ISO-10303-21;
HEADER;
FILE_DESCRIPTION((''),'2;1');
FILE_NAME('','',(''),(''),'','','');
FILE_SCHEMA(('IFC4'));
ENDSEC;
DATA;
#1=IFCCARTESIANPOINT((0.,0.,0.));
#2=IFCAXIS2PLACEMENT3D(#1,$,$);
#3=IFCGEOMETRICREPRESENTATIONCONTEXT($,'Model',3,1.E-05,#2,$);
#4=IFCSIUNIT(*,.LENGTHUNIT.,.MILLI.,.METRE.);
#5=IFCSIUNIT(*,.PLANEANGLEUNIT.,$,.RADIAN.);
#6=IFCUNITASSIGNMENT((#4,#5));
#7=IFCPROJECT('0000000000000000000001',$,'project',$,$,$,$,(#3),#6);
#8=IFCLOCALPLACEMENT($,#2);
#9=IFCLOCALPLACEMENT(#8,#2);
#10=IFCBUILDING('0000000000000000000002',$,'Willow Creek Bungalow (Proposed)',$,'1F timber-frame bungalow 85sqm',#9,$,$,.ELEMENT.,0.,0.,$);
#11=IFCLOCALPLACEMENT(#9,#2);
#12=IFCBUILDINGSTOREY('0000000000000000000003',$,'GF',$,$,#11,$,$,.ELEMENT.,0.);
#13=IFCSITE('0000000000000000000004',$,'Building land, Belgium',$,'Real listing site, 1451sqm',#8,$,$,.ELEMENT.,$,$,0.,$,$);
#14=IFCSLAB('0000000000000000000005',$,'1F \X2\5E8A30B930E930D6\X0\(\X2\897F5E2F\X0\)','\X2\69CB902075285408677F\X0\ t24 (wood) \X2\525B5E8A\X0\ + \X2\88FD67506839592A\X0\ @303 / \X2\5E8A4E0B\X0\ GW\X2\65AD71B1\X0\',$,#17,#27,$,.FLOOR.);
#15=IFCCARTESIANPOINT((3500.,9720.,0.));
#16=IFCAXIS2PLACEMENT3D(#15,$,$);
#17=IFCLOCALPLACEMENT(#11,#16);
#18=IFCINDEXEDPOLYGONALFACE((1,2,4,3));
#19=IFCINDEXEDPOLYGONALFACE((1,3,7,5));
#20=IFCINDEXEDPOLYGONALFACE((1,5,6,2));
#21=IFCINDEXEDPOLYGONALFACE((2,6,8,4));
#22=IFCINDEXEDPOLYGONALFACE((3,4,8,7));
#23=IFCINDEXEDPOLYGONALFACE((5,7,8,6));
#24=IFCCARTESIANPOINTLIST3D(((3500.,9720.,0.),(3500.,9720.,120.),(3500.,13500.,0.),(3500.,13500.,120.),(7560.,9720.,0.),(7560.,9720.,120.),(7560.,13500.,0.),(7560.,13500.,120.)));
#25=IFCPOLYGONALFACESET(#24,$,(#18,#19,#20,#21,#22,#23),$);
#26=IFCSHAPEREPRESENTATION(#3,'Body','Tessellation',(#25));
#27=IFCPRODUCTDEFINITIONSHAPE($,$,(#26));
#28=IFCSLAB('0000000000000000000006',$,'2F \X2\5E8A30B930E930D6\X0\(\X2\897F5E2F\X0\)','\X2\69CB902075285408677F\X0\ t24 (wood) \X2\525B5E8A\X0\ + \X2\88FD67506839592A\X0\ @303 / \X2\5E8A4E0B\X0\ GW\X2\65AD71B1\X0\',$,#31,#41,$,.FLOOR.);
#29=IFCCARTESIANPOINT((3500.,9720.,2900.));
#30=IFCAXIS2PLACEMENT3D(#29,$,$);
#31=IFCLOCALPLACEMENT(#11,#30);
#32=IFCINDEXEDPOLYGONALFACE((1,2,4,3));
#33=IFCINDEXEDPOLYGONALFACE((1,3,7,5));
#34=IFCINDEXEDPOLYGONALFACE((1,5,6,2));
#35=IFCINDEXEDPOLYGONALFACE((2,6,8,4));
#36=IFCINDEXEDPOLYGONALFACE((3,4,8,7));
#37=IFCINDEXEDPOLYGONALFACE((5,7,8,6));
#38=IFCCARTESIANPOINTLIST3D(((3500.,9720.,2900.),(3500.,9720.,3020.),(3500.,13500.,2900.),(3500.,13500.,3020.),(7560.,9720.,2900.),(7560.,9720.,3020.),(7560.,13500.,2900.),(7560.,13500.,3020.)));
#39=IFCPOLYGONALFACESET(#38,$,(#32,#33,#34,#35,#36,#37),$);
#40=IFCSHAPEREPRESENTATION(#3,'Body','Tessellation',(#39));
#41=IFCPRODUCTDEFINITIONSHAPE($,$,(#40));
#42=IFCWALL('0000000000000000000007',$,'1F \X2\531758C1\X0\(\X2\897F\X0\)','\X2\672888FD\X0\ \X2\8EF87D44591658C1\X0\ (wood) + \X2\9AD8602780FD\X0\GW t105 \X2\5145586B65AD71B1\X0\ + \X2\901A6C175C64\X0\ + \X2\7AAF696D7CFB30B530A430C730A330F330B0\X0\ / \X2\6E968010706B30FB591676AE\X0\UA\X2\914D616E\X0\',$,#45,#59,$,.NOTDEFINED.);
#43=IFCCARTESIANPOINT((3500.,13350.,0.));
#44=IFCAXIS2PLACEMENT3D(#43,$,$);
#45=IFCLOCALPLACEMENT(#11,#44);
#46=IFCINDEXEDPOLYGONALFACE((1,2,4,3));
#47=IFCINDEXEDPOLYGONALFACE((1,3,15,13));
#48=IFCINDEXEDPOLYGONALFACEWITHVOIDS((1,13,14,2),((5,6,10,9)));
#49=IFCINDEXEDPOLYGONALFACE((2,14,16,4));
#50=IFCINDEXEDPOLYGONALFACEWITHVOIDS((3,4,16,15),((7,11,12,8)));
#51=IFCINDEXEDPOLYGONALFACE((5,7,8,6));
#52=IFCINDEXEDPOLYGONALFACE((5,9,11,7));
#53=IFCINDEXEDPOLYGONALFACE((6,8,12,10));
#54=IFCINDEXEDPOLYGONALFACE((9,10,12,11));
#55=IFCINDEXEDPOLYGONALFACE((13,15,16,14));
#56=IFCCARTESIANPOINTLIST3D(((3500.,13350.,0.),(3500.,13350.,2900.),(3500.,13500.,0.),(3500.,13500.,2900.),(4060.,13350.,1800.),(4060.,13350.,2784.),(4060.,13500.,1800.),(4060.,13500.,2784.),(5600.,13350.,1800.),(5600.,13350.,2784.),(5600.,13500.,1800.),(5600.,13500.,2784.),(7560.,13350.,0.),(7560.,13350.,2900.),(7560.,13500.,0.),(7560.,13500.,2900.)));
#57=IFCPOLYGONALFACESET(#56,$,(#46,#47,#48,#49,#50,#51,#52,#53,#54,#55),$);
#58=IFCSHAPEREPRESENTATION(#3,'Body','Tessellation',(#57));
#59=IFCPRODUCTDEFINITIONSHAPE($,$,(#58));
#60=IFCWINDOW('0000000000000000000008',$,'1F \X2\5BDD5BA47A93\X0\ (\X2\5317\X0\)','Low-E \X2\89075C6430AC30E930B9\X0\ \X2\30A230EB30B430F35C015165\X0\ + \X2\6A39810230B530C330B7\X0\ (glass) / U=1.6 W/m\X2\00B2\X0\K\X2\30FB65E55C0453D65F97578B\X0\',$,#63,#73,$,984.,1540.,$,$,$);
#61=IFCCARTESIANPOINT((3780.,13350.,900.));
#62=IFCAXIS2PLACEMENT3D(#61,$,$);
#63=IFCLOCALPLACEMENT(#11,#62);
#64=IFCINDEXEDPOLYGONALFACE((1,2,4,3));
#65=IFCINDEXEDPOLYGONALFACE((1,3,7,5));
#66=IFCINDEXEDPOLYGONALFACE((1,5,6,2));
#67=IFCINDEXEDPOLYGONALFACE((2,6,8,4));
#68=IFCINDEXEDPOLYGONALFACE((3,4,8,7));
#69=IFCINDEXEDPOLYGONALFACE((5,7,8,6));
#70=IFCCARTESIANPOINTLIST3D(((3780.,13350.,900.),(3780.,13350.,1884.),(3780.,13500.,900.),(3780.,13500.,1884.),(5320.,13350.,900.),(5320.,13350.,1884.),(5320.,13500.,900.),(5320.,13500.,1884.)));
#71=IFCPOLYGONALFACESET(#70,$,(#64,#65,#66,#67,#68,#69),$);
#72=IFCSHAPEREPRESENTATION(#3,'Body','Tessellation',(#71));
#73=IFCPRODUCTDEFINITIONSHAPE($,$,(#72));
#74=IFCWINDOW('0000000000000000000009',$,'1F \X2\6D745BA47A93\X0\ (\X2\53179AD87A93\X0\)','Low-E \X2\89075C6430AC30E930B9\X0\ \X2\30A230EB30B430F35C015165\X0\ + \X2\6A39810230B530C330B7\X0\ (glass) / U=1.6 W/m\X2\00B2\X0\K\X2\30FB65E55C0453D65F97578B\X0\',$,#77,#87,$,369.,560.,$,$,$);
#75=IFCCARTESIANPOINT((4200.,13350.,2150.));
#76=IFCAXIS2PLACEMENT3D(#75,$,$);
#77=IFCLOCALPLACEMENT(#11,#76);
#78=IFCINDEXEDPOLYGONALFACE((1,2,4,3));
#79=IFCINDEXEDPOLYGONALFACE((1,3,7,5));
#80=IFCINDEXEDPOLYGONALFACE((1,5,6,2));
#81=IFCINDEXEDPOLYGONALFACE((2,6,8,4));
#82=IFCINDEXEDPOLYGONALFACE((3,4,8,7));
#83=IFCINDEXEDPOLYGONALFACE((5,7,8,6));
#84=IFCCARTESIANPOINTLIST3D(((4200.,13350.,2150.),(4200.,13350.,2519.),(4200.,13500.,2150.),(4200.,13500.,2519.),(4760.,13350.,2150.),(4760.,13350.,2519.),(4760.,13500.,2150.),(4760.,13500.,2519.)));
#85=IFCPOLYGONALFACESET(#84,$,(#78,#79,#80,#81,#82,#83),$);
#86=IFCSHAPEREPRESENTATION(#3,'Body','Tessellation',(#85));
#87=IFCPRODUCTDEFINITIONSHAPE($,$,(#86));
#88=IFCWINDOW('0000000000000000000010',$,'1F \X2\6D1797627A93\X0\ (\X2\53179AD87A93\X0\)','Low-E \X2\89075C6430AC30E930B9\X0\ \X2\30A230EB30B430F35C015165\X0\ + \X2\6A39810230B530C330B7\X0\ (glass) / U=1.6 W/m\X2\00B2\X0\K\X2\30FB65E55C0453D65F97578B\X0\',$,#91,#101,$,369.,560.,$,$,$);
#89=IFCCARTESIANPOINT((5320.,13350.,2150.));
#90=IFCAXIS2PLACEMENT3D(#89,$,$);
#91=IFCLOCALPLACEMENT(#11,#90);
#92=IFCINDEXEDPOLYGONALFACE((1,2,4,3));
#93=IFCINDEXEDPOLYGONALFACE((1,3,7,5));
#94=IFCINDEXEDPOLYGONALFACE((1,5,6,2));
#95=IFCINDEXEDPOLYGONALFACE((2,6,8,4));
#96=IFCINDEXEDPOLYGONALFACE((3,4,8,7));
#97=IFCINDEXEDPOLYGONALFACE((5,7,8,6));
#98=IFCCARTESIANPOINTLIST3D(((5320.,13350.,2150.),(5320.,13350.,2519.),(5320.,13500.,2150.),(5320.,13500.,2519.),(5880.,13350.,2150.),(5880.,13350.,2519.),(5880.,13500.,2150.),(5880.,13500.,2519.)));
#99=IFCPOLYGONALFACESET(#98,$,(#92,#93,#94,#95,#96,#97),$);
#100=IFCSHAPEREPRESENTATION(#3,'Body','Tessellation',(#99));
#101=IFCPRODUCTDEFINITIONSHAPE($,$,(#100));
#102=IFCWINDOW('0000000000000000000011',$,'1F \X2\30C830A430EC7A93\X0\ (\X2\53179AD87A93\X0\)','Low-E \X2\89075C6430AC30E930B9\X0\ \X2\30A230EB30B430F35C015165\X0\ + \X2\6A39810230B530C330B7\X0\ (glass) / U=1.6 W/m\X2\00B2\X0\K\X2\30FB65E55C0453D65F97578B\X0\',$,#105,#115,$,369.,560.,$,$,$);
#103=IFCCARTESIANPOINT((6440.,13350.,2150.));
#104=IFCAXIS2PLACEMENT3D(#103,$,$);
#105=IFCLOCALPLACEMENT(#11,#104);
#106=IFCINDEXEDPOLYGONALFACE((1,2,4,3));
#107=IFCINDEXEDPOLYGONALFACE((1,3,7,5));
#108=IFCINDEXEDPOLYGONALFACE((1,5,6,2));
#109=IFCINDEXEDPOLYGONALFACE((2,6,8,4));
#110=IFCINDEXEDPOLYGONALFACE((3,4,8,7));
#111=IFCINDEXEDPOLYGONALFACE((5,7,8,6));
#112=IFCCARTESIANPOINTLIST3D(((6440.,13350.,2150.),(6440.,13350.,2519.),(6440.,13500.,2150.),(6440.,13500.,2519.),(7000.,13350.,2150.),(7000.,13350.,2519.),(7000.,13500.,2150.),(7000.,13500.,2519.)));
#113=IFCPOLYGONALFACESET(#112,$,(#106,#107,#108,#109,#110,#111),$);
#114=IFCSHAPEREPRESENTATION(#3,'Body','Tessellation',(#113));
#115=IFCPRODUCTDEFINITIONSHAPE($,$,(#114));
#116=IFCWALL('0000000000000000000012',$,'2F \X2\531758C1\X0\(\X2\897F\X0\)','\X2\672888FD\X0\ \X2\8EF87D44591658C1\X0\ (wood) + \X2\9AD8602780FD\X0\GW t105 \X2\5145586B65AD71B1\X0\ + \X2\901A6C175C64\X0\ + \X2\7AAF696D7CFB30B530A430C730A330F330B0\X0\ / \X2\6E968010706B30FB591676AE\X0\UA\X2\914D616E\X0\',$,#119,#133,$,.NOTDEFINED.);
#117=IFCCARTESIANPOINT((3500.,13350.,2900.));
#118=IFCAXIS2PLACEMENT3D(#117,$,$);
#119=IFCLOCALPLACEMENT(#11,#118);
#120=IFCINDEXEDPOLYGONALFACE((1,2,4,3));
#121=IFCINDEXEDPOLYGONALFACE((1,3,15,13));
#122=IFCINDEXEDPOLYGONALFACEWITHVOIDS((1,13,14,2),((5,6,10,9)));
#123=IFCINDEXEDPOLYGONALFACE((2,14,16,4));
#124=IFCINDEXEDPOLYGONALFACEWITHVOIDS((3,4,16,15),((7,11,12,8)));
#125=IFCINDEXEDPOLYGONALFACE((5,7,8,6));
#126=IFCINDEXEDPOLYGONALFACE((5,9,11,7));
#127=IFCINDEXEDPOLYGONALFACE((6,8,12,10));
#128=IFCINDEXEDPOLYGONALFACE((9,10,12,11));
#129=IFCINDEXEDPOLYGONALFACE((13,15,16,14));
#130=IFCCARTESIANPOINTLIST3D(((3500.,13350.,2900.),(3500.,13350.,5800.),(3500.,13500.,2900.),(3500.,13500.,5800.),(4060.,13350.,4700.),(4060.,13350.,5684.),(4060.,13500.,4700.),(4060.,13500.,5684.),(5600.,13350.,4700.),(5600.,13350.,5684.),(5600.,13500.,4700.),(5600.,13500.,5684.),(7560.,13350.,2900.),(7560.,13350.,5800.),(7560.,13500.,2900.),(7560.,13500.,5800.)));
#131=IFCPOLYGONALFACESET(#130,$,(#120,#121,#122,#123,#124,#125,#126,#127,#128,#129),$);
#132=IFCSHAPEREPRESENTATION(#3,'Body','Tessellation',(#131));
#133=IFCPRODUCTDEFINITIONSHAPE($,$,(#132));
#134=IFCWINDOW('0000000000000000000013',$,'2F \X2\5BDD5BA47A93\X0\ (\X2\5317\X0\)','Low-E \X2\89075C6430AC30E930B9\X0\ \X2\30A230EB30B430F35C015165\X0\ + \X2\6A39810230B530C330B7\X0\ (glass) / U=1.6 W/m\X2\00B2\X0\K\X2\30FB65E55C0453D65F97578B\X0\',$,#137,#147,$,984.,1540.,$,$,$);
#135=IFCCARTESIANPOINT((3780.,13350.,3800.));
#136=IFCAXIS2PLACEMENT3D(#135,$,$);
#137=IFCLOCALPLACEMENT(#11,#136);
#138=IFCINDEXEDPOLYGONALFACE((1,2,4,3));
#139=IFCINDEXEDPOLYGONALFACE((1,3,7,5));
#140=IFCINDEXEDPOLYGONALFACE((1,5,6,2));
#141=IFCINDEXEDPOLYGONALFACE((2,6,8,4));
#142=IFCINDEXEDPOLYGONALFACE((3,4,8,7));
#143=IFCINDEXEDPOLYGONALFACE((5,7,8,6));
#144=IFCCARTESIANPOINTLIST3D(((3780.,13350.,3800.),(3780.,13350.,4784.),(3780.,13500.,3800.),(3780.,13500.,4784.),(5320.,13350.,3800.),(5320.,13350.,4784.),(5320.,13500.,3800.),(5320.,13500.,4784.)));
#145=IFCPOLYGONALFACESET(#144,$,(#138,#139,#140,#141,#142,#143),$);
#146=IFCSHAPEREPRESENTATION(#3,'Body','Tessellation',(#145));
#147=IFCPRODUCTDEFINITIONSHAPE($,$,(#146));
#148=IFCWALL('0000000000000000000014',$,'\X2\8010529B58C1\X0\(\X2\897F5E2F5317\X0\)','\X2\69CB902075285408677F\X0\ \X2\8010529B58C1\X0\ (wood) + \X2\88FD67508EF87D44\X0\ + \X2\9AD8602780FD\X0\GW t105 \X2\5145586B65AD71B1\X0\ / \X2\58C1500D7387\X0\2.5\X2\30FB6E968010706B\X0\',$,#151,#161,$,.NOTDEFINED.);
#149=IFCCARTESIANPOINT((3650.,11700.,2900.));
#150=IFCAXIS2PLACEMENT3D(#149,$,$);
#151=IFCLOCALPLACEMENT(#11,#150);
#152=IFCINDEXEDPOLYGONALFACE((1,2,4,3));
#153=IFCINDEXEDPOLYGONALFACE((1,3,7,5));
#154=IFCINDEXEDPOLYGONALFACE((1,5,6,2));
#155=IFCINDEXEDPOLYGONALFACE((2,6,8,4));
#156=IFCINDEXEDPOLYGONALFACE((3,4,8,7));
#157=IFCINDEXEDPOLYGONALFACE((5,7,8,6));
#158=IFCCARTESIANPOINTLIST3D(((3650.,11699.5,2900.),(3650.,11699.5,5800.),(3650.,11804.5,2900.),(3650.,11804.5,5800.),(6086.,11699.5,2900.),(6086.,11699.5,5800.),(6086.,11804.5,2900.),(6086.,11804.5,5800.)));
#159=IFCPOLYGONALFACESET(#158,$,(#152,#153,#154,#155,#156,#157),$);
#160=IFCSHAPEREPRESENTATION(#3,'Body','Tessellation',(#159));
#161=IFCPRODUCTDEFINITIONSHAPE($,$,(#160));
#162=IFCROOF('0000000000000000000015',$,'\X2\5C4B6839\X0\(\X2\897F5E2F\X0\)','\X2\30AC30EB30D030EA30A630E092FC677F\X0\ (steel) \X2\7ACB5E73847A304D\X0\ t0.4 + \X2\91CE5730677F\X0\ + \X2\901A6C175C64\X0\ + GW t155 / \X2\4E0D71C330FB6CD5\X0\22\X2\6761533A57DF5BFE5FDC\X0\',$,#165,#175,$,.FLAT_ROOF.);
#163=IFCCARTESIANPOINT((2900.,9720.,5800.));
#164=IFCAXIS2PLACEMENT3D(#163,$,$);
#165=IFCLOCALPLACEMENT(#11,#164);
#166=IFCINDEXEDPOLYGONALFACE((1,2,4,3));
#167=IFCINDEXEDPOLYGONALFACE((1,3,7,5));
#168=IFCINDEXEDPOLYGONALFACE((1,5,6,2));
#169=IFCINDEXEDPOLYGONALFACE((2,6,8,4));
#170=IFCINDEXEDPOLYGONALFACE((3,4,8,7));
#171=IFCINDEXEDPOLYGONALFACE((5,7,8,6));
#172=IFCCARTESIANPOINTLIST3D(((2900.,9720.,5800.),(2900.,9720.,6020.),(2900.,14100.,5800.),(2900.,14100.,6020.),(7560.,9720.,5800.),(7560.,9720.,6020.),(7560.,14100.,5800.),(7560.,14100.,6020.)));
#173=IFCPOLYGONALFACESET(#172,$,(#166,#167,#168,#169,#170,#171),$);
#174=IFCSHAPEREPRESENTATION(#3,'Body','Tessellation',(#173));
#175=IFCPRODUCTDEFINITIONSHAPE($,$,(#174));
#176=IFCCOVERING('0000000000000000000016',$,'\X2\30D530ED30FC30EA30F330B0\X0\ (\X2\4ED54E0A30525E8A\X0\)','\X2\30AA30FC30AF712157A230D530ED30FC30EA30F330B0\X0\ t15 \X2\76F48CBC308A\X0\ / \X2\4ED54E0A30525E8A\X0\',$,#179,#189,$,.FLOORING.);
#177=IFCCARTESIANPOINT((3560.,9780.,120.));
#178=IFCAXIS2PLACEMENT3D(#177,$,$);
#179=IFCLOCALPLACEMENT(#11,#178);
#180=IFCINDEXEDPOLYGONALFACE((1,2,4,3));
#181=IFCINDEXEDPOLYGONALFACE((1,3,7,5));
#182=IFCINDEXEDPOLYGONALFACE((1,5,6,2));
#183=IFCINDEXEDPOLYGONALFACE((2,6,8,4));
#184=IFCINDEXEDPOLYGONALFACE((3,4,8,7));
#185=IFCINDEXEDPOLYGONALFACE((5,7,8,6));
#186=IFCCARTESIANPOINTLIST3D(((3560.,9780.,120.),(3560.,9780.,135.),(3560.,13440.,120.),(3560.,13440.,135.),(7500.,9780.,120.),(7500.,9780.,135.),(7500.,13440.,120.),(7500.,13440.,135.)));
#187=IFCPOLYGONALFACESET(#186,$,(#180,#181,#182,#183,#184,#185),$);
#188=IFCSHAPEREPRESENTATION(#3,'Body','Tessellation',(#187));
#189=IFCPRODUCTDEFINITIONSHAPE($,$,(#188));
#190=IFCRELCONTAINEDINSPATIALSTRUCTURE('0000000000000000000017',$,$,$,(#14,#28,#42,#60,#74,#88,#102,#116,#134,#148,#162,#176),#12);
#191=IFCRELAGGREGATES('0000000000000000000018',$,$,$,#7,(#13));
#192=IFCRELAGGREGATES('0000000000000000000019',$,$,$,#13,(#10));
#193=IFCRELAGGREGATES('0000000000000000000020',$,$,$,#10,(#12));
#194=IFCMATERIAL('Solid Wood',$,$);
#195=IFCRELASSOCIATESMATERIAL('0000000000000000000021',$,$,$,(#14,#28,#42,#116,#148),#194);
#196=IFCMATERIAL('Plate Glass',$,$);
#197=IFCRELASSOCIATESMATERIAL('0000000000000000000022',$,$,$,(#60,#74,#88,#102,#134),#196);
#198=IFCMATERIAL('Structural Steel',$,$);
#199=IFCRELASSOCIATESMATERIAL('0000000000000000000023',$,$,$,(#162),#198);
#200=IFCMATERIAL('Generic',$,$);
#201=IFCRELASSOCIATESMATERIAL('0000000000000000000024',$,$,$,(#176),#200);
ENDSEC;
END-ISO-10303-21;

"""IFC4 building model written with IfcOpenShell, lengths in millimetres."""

from ifc_helpers import new_model, si_unit, frame, frame_2d, origin, place, context, project, spatial, rectangle, extrude, material, element, fill, save


model = new_model("IFC4")

# Units and contexts
model_context = context("Model", 3, precision=1e-05, world=origin())
ifc_project = project(units=[si_unit("LENGTHUNIT", "METRE", prefix="MILLI"), si_unit("PLANEANGLEUNIT", "RADIAN")], contexts=[model_context])

# Site, building, storey
site_placement = place(None, origin())
site = spatial("IfcSite", under=ifc_project, at=site_placement, Name="Building land, Belgium", ObjectType="Real listing site, 1451sqm", CompositionType="ELEMENT", RefElevation=0.0)
building_placement = place(site_placement, origin())
building = spatial("IfcBuilding", under=site, at=building_placement, Name="Willow Creek Bungalow (Proposed)", ObjectType="1F timber-frame bungalow 85sqm", CompositionType="ELEMENT", ElevationOfRefHeight=0.0, ElevationOfTerrain=0.0)
storey_placement = place(building_placement, origin())
storey = spatial("IfcBuildingStorey", under=building, at=storey_placement, Name="GF", CompositionType="ELEMENT", Elevation=0.0)

# Slabs
ifc_material_1 = material(Name="Solid Wood")
slab_1_placement = place(storey_placement, frame((3500.0, 9720.0, 0.0)))
element("IfcSlab", 1, at=slab_1_placement, inside=storey, material=ifc_material_1, Name="1F 床スラブ(西帯)", Description="構造用合板 t24 (wood) 剛床 + 製材根太 @303 / 床下 GW断熱", PredefinedType="FLOOR", context=model_context, shape_type="SweptSolid", body=[
    extrude(rectangle(XDim=4060.0, YDim=3780.0, at=frame_2d((2030.0, 1890.0))), frame((3500.0, 9720.0, 0.0)), (0.0, 0.0, 1.0), 120.0),
])
slab_2_placement = place(storey_placement, frame((3500.0, 9720.0, 2900.0)))
element("IfcSlab", 2, at=slab_2_placement, inside=storey, material=ifc_material_1, Name="2F 床スラブ(西帯)", Description="構造用合板 t24 (wood) 剛床 + 製材根太 @303 / 床下 GW断熱", PredefinedType="FLOOR", context=model_context, shape_type="SweptSolid", body=[
    extrude(rectangle(XDim=4060.0, YDim=3780.0, at=frame_2d((2030.0, 1890.0))), frame((3500.0, 9720.0, 2900.0)), (0.0, 0.0, 1.0), 120.0),
])

# Wall, openings, windows
wall_1_placement = place(storey_placement, frame((3500.0, 13350.0, 0.0)))
wall_1 = element("IfcWall", 3, at=wall_1_placement, inside=storey, material=ifc_material_1, Name="1F 北壁(西)", Description="木製 軸組外壁 (wood) + 高性能GW t105 充填断熱 + 通気層 + 窯業系サイディング / 準耐火・外皮UA配慮", PredefinedType="NOTDEFINED", context=model_context, shape_type="SweptSolid", body=[
    extrude(rectangle(XDim=4060.0, YDim=150.0, at=frame_2d((2030.0, 75.0))), frame((3500.0, 13350.0, 0.0)), (0.0, 0.0, 1.0), 2900.0),
])
opening_1_placement = place(storey_placement, frame((3780.0, 13350.0, 900.0)))
opening_1 = element("IfcOpeningElement", 4, at=opening_1_placement, cuts=wall_1, PredefinedType="NOTDEFINED", context=model_context, shape_type="SweptSolid", body=[
    extrude(rectangle(XDim=1540.0, YDim=150.0, at=frame_2d((770.0, 75.0))), frame((3780.0, 13350.0, 900.0)), (0.0, 0.0, 1.0), 984.0),
])
opening_2_placement = place(storey_placement, frame((4200.0, 13350.0, 2150.0)))
opening_2 = element("IfcOpeningElement", 5, at=opening_2_placement, cuts=wall_1, PredefinedType="NOTDEFINED", context=model_context, shape_type="SweptSolid", body=[
    extrude(rectangle(XDim=560.0, YDim=150.0, at=frame_2d((280.0, 75.0))), frame((4200.0, 13350.0, 2150.0)), (0.0, 0.0, 1.0), 369.0),
])
opening_3_placement = place(storey_placement, frame((5320.0, 13350.0, 2150.0)))
opening_3 = element("IfcOpeningElement", 6, at=opening_3_placement, cuts=wall_1, PredefinedType="NOTDEFINED", context=model_context, shape_type="SweptSolid", body=[
    extrude(rectangle(XDim=560.0, YDim=150.0, at=frame_2d((280.0, 75.0))), frame((5320.0, 13350.0, 2150.0)), (0.0, 0.0, 1.0), 369.0),
])
opening_4_placement = place(storey_placement, frame((6440.0, 13350.0, 2150.0)))
opening_4 = element("IfcOpeningElement", 7, at=opening_4_placement, cuts=wall_1, PredefinedType="NOTDEFINED", context=model_context, shape_type="SweptSolid", body=[
    extrude(rectangle(XDim=560.0, YDim=150.0, at=frame_2d((280.0, 75.0))), frame((6440.0, 13350.0, 2150.0)), (0.0, 0.0, 1.0), 369.0),
])
ifc_material_2 = material(Name="Plate Glass")
window_1_placement = place(storey_placement, frame((3780.0, 13350.0, 900.0)))
window_1 = element("IfcWindow", 8, at=window_1_placement, inside=storey, material=ifc_material_2, Name="1F 寝室窓 (北)", Description="Low-E 複層ガラス アルゴン封入 + 樹脂サッシ (glass) / U=1.6 W/m²K・日射取得型", OverallHeight=984.0, OverallWidth=1540.0, context=model_context, shape_type="SweptSolid", body=[
    extrude(rectangle(XDim=1540.0, YDim=150.0, at=frame_2d((770.0, 75.0))), frame((3780.0, 13350.0, 900.0)), (0.0, 0.0, 1.0), 984.0),
])
fill(opening_1, window_1)
window_2_placement = place(storey_placement, frame((4200.0, 13350.0, 2150.0)))
window_2 = element("IfcWindow", 9, at=window_2_placement, inside=storey, material=ifc_material_2, Name="1F 浴室窓 (北高窓)", Description="Low-E 複層ガラス アルゴン封入 + 樹脂サッシ (glass) / U=1.6 W/m²K・日射取得型", OverallHeight=369.0, OverallWidth=560.0, context=model_context, shape_type="SweptSolid", body=[
    extrude(rectangle(XDim=560.0, YDim=150.0, at=frame_2d((280.0, 75.0))), frame((4200.0, 13350.0, 2150.0)), (0.0, 0.0, 1.0), 369.0),
])
fill(opening_2, window_2)
window_3_placement = place(storey_placement, frame((5320.0, 13350.0, 2150.0)))
window_3 = element("IfcWindow", 10, at=window_3_placement, inside=storey, material=ifc_material_2, Name="1F 洗面窓 (北高窓)", Description="Low-E 複層ガラス アルゴン封入 + 樹脂サッシ (glass) / U=1.6 W/m²K・日射取得型", OverallHeight=369.0, OverallWidth=560.0, context=model_context, shape_type="SweptSolid", body=[
    extrude(rectangle(XDim=560.0, YDim=150.0, at=frame_2d((280.0, 75.0))), frame((5320.0, 13350.0, 2150.0)), (0.0, 0.0, 1.0), 369.0),
])
fill(opening_3, window_3)
window_4_placement = place(storey_placement, frame((6440.0, 13350.0, 2150.0)))
window_4 = element("IfcWindow", 11, at=window_4_placement, inside=storey, material=ifc_material_2, Name="1F トイレ窓 (北高窓)", Description="Low-E 複層ガラス アルゴン封入 + 樹脂サッシ (glass) / U=1.6 W/m²K・日射取得型", OverallHeight=369.0, OverallWidth=560.0, context=model_context, shape_type="SweptSolid", body=[
    extrude(rectangle(XDim=560.0, YDim=150.0, at=frame_2d((280.0, 75.0))), frame((6440.0, 13350.0, 2150.0)), (0.0, 0.0, 1.0), 369.0),
])
fill(opening_4, window_4)

# Wall, opening, window
wall_2_placement = place(storey_placement, frame((3500.0, 13350.0, 2900.0)))
wall_2 = element("IfcWall", 12, at=wall_2_placement, inside=storey, material=ifc_material_1, Name="2F 北壁(西)", Description="木製 軸組外壁 (wood) + 高性能GW t105 充填断熱 + 通気層 + 窯業系サイディング / 準耐火・外皮UA配慮", PredefinedType="NOTDEFINED", context=model_context, shape_type="SweptSolid", body=[
    extrude(rectangle(XDim=4060.0, YDim=150.0, at=frame_2d((2030.0, 75.0))), frame((3500.0, 13350.0, 2900.0)), (0.0, 0.0, 1.0), 2900.0),
])
opening_5_placement = place(storey_placement, frame((3780.0, 13350.0, 3800.0)))
opening_5 = element("IfcOpeningElement", 13, at=opening_5_placement, cuts=wall_2, PredefinedType="NOTDEFINED", context=model_context, shape_type="SweptSolid", body=[
    extrude(rectangle(XDim=1540.0, YDim=150.0, at=frame_2d((770.0, 75.0))), frame((3780.0, 13350.0, 3800.0)), (0.0, 0.0, 1.0), 984.0),
])
window_5_placement = place(storey_placement, frame((3780.0, 13350.0, 3800.0)))
window_5 = element("IfcWindow", 14, at=window_5_placement, inside=storey, material=ifc_material_2, Name="2F 寝室窓 (北)", Description="Low-E 複層ガラス アルゴン封入 + 樹脂サッシ (glass) / U=1.6 W/m²K・日射取得型", OverallHeight=984.0, OverallWidth=1540.0, context=model_context, shape_type="SweptSolid", body=[
    extrude(rectangle(XDim=1540.0, YDim=150.0, at=frame_2d((770.0, 75.0))), frame((3780.0, 13350.0, 3800.0)), (0.0, 0.0, 1.0), 984.0),
])
fill(opening_5, window_5)

# Wall
wall_3_placement = place(storey_placement, frame((3650.0, 11700.0, 2900.0)))
element("IfcWall", 15, at=wall_3_placement, inside=storey, material=ifc_material_1, Name="耐力壁(西帯北)", Description="構造用合板 耐力壁 (wood) + 製材軸組 + 高性能GW t105 充填断熱 / 壁倍率2.5・準耐火", PredefinedType="NOTDEFINED", context=model_context, shape_type="SweptSolid", body=[
    extrude(rectangle(XDim=2436.0, YDim=105.0, at=frame_2d((1218.0, 52.0))), frame((3650.0, 11700.0, 2900.0)), (0.0, 0.0, 1.0), 2900.0),
])

# Roof
ifc_material_3 = material(Name="Structural Steel")
for number, where, name in (
    (16, (2900.0, 9720.0, 5800.0), "屋根(西帯)"),
):
    element("IfcRoof", number, at=place(storey_placement, frame(where)), inside=storey, material=ifc_material_3, Name=name, Description="ガルバリウム鋼板 (steel) 立平葺き t0.4 + 野地板 + 通気層 + GW t155 / 不燃・法22条区域対応", PredefinedType="FLAT_ROOF", context=model_context, shape_type="SweptSolid", body=[
        extrude(rectangle(XDim=4660.0, YDim=4380.0, at=frame_2d((2330.0, 2190.0))), frame((2900.0, 9720.0, 5800.0)), (0.0, 0.0, 1.0), 220.0),
    ])

# Covering
ifc_material_4 = material(Name="Generic")
covering_1_placement = place(storey_placement, frame((3560.0, 9780.0, 120.0)))
element("IfcCovering", 17, at=covering_1_placement, inside=storey, material=ifc_material_4, Name="フローリング (仕上げ床)", Description="オーク無垢フローリング t15 直貼り / 仕上げ床", PredefinedType="FLOORING", context=model_context, shape_type="SweptSolid", body=[
    extrude(rectangle(XDim=3940.0, YDim=3660.0, at=frame_2d((1970.0, 1830.0))), frame((3560.0, 9780.0, 120.0)), (0.0, 0.0, 1.0), 15.0),
])

save(model, "model.ifc")
